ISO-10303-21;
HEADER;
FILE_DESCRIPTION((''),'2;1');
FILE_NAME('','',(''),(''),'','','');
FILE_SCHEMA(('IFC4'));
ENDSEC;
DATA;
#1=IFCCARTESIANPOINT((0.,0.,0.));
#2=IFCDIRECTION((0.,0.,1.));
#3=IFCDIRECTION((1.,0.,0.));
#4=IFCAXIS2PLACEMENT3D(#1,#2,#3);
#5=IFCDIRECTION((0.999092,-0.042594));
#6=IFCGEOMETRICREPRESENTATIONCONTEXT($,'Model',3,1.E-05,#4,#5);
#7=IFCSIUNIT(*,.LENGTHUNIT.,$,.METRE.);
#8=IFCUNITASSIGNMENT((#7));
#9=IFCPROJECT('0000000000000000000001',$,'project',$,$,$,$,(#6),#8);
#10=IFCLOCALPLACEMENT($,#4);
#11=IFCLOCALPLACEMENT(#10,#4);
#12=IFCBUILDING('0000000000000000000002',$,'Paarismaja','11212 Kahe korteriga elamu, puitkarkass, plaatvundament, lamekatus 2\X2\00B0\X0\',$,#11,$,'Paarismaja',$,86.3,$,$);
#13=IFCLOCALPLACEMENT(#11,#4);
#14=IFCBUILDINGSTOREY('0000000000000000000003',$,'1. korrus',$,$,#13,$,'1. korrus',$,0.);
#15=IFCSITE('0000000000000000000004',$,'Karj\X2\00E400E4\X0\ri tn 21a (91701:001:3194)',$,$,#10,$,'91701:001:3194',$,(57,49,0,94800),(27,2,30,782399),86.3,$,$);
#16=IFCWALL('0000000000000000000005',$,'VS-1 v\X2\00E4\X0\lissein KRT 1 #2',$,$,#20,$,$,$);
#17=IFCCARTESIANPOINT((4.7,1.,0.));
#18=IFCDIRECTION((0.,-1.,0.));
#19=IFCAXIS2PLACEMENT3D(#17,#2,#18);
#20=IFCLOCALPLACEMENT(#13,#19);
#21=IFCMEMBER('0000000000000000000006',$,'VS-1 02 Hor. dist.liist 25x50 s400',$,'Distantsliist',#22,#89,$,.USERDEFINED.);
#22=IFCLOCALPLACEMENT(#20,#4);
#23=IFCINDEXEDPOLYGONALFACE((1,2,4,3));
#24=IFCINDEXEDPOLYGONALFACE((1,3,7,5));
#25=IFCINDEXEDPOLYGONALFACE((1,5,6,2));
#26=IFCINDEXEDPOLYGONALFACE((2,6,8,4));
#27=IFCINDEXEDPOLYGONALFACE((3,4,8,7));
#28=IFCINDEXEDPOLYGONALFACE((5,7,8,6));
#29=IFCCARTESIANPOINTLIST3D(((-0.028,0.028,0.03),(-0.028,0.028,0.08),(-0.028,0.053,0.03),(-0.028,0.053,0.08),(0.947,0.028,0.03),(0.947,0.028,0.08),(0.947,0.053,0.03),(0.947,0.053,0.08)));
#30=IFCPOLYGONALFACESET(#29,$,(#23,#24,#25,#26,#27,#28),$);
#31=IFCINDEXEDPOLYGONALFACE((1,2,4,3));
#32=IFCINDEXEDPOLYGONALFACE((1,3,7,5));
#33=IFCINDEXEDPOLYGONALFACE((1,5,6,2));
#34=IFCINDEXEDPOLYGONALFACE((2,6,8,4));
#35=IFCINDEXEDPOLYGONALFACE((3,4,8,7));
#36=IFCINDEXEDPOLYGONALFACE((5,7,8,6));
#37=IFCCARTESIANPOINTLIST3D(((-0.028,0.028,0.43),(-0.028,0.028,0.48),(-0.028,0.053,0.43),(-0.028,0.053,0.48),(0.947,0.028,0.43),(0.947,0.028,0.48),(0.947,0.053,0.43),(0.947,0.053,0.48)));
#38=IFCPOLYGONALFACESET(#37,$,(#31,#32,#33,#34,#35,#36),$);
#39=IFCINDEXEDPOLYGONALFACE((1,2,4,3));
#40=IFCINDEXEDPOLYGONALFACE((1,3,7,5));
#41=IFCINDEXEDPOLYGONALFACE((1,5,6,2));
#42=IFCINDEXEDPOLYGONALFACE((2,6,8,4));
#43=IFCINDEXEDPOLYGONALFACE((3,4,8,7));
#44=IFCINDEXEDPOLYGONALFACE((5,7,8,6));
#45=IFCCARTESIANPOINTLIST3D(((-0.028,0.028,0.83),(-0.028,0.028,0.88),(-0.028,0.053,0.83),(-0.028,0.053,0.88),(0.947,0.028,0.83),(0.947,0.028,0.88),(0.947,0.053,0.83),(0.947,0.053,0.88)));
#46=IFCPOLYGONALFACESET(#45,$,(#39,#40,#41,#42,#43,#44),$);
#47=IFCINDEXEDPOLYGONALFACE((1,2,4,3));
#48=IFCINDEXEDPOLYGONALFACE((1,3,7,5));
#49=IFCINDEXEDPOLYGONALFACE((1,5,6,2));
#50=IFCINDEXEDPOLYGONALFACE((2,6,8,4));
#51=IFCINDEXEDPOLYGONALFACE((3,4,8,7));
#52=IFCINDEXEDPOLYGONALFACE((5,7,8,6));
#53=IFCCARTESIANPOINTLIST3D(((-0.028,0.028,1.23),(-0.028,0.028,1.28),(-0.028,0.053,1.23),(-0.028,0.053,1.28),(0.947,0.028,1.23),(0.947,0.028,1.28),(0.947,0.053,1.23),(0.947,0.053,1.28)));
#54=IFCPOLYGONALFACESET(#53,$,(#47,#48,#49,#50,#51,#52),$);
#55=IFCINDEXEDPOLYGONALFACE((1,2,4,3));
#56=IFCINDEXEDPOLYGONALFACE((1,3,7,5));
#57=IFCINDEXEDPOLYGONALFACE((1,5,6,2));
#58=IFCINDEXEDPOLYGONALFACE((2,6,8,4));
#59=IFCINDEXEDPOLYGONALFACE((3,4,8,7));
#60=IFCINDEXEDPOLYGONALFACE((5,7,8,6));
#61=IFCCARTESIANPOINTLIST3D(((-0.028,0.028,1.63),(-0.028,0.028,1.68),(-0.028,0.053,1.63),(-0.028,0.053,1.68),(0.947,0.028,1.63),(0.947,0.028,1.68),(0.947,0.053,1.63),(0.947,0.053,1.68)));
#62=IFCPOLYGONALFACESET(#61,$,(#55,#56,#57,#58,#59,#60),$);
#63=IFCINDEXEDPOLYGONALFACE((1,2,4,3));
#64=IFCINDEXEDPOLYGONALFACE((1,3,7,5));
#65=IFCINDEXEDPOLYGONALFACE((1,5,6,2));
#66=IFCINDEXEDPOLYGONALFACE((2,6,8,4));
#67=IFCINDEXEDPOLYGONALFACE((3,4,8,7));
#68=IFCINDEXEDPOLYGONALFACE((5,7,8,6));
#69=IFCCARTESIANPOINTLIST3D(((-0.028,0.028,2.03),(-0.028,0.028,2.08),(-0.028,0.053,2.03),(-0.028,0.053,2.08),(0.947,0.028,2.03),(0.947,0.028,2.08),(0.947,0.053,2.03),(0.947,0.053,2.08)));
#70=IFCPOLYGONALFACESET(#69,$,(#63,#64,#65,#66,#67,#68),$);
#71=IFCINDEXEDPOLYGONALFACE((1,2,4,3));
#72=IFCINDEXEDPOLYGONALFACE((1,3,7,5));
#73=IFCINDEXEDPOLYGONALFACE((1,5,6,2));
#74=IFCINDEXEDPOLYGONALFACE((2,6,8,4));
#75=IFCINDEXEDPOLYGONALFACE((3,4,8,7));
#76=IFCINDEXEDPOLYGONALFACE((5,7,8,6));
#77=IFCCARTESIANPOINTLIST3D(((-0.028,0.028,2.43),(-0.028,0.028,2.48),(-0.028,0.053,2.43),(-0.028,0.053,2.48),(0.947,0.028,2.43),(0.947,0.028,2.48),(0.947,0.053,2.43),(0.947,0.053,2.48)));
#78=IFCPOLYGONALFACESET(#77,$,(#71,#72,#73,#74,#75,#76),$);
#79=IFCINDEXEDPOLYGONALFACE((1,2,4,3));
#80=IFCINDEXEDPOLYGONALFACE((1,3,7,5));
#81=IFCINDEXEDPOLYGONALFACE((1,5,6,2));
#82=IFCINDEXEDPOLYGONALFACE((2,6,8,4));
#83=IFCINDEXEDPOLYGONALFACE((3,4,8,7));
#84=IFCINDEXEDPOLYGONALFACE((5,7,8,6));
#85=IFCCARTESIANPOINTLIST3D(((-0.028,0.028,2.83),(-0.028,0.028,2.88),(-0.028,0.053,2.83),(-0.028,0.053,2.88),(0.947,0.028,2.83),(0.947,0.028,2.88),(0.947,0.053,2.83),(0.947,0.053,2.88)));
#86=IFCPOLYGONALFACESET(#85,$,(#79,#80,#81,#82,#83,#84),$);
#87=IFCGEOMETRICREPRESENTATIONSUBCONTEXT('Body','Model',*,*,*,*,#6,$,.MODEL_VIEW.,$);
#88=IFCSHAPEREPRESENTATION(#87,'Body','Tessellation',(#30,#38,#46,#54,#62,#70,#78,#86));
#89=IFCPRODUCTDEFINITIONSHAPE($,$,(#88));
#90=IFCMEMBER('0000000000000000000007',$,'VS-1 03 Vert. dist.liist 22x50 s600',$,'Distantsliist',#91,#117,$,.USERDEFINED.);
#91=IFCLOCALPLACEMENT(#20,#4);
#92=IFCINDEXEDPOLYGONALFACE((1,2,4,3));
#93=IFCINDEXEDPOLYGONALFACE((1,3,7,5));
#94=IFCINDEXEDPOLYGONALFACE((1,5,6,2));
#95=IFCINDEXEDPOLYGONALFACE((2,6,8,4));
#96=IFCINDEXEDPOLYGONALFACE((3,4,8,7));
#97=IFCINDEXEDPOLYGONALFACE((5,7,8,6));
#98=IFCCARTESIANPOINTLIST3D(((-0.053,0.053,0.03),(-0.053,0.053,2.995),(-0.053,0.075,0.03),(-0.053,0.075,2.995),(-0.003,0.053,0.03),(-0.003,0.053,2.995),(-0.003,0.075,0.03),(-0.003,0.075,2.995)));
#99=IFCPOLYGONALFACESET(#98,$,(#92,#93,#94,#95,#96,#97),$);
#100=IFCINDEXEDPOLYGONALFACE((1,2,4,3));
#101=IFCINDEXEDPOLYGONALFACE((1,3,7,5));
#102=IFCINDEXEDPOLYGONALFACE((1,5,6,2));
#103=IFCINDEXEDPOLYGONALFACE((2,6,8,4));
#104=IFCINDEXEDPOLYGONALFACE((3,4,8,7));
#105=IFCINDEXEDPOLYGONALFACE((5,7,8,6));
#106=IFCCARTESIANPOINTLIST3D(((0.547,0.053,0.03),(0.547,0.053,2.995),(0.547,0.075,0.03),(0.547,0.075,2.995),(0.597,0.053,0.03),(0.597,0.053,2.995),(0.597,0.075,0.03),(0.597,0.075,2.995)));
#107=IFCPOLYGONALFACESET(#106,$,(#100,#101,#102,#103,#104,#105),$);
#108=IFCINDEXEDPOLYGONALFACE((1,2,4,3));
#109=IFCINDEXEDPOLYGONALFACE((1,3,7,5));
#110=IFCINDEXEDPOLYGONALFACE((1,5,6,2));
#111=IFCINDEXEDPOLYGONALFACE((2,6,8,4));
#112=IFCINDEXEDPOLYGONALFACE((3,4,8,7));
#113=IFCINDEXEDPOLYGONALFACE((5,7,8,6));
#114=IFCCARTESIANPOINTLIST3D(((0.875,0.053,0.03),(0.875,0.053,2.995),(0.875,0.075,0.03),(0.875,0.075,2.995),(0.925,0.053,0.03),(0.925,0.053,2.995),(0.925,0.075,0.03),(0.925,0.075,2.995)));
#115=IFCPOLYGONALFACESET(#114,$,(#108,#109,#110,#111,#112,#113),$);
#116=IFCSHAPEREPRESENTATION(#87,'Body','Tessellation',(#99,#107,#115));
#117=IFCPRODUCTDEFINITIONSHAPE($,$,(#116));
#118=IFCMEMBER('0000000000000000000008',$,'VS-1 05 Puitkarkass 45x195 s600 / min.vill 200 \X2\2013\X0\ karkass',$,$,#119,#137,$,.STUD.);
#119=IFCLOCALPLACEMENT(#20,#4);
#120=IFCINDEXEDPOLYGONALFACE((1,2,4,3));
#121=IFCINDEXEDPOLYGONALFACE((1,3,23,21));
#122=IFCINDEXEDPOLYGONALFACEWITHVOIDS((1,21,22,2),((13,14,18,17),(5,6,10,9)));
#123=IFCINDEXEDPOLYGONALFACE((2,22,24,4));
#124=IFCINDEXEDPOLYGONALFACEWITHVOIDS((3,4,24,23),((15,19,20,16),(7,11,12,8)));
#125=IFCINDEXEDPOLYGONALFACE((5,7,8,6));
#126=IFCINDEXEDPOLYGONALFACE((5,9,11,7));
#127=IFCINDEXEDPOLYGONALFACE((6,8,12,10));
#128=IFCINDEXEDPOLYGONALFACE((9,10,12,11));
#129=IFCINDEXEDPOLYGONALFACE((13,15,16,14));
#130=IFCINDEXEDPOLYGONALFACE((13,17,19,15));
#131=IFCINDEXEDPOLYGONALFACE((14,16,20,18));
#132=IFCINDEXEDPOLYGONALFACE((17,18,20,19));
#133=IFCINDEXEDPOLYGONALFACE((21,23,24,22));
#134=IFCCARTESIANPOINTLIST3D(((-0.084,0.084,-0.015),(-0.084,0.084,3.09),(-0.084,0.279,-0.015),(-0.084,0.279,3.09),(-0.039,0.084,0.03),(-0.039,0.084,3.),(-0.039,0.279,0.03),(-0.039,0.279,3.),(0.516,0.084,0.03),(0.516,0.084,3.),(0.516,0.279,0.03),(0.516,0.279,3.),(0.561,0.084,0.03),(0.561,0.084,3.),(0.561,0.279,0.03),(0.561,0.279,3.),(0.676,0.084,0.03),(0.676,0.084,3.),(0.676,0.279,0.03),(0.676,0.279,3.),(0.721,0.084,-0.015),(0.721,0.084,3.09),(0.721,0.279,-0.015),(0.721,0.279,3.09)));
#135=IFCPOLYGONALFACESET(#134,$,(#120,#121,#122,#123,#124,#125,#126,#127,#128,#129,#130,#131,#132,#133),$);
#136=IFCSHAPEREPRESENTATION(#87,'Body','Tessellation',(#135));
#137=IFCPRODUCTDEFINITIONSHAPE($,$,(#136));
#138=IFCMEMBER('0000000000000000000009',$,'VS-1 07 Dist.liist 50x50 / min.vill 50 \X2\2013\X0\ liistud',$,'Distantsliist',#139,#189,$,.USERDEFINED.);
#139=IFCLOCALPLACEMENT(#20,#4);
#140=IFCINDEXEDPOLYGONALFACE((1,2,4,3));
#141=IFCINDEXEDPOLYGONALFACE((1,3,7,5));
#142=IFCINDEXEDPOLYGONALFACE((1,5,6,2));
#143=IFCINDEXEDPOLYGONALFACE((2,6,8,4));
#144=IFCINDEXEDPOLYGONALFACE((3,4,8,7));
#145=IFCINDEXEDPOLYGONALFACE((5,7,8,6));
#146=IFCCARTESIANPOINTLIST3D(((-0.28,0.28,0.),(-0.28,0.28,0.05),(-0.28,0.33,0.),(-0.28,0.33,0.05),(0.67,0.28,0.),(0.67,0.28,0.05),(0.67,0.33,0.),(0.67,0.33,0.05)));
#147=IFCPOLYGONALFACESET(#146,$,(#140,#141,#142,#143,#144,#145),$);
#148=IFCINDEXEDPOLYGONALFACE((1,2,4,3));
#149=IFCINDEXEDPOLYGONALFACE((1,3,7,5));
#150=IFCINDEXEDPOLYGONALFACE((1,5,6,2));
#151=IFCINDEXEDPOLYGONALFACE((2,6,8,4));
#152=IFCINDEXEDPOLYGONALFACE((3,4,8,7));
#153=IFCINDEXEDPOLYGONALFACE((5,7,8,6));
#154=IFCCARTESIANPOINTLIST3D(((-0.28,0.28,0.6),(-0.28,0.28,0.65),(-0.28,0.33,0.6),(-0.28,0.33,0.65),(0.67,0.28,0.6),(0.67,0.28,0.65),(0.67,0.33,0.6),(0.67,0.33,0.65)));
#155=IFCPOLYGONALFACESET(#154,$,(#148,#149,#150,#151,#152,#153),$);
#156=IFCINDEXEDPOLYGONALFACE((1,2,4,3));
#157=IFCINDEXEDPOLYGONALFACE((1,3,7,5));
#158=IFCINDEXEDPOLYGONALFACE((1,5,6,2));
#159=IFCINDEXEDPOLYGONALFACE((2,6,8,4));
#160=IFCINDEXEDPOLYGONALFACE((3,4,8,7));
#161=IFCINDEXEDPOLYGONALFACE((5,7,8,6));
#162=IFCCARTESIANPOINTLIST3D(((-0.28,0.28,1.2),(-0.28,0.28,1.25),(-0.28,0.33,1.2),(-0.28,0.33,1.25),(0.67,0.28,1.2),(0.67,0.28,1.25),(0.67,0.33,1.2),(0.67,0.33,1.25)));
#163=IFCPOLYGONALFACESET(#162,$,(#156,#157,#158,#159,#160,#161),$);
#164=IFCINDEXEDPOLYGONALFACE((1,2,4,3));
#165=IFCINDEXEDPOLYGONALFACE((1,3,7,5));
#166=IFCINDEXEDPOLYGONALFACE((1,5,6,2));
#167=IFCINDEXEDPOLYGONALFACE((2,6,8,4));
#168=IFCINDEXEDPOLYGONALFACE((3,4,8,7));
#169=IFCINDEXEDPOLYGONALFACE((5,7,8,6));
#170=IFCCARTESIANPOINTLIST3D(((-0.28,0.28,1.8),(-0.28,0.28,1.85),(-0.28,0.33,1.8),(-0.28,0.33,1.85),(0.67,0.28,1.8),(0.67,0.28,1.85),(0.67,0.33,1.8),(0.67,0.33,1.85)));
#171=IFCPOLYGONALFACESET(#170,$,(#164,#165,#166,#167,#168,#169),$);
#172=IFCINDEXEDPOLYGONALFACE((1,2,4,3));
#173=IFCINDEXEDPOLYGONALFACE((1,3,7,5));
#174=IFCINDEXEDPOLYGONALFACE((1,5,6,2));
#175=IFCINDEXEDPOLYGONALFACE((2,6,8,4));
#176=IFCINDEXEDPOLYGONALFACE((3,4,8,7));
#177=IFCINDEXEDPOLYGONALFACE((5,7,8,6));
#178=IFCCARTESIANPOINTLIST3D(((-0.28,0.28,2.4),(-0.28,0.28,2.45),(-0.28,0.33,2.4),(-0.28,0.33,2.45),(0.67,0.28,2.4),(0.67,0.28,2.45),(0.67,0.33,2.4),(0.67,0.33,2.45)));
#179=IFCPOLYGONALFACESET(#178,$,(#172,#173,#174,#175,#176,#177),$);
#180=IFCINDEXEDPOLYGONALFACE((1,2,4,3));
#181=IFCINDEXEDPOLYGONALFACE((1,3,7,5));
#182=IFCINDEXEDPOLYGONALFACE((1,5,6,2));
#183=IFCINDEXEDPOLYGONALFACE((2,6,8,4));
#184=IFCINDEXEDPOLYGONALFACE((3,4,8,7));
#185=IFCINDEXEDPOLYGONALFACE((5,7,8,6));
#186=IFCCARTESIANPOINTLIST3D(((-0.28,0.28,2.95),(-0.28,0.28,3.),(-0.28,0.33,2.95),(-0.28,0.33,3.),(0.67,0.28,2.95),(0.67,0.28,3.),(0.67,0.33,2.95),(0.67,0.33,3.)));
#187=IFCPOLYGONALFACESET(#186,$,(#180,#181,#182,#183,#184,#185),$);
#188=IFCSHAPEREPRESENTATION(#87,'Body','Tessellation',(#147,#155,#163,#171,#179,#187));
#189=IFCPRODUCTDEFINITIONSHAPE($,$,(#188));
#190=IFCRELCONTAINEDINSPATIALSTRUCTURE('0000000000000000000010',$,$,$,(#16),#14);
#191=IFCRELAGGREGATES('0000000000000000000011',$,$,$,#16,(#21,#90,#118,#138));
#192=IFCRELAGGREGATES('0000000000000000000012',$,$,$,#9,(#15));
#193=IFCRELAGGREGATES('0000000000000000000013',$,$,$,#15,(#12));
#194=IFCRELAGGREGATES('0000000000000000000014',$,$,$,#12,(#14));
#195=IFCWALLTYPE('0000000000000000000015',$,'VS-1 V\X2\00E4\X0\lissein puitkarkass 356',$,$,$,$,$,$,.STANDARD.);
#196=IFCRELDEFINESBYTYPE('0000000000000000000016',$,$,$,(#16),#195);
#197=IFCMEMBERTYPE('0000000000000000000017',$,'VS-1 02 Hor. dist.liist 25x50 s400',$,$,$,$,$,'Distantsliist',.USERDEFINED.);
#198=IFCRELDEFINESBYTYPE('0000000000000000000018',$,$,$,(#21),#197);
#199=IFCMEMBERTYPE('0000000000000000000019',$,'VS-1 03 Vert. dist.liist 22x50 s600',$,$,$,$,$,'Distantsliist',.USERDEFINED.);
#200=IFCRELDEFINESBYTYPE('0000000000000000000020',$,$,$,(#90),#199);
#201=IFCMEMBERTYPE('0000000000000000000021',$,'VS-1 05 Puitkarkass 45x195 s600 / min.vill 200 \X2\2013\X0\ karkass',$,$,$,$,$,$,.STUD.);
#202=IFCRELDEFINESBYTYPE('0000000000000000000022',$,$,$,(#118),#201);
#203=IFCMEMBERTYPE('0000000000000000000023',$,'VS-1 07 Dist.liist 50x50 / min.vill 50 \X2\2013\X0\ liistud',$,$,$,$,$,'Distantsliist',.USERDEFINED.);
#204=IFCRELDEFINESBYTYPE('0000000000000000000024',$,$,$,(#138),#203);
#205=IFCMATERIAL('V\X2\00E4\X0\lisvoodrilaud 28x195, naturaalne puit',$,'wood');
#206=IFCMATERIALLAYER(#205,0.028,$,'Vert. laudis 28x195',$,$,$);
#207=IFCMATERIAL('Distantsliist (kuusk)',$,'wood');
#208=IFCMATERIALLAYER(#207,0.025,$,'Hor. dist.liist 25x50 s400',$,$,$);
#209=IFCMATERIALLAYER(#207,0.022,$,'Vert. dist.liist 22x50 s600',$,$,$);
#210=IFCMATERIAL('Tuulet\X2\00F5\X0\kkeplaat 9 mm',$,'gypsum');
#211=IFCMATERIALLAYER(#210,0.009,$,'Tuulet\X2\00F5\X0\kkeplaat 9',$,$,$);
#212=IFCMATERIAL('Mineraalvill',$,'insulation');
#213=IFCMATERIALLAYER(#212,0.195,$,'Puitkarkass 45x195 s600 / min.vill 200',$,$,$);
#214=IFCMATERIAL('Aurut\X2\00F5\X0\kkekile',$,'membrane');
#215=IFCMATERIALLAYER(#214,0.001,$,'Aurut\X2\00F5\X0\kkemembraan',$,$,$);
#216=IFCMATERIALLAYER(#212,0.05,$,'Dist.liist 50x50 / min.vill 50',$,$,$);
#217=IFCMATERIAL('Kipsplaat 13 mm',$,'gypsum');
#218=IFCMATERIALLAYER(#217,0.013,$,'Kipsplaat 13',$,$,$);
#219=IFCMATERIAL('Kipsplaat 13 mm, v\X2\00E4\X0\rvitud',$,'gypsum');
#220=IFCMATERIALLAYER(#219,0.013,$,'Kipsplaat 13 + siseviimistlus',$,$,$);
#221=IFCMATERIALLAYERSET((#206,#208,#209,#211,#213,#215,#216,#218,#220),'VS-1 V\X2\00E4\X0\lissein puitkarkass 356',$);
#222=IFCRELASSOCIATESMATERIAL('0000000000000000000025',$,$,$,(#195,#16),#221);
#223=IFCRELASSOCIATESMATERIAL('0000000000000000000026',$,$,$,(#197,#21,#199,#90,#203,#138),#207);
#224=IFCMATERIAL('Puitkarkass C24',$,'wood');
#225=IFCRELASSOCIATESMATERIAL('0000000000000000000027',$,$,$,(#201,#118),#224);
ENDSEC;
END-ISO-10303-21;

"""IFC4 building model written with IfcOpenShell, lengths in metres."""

from ifc_helpers import new_model, si_unit, direction, frame, origin_with_axes, place, context, subcontext, project, spatial, indexed_curve, outline, extrude, material, layer, layer_set, layer_usage, type_object, element, aggregate, save


model = new_model("IFC4")

# Units and contexts
model_context = context("Model", 3, precision=1e-05, world=origin_with_axes(), true_north=direction((0.999092, -0.042594)))
body_context = subcontext(model_context, "Body", "Model", "MODEL_VIEW")
ifc_project = project(units=[si_unit("LENGTHUNIT", "METRE")], contexts=[model_context])

# Site, building, storey
site_placement = place(None, origin_with_axes())
site = spatial("IfcSite", under=ifc_project, at=site_placement, Name="Karjääri tn 21a (91701:001:3194)", LongName="91701:001:3194", RefLatitude=(57, 49, 0, 94800), RefLongitude=(27, 2, 30, 782399), RefElevation=86.3)
building_placement = place(site_placement, origin_with_axes())
building = spatial("IfcBuilding", under=site, at=building_placement, Name="Paarismaja", Description="11212 Kahe korteriga elamu, puitkarkass, plaatvundament, lamekatus 2°", LongName="Paarismaja", ElevationOfRefHeight=86.3)
storey_placement = place(building_placement, origin_with_axes())
storey = spatial("IfcBuildingStorey", under=building, at=storey_placement, Name="1. korrus", LongName="1. korrus", Elevation=0.0)

# Wall, members
ifc_material_1 = material(Name="Välisvoodrilaud 28x195, naturaalne puit", Category="wood")
ifc_layer_1 = layer(ifc_material_1, 0.028, Name="Vert. laudis 28x195")
ifc_material_2 = material(Name="Distantsliist (kuusk)", Category="wood")
ifc_layer_2 = layer(ifc_material_2, 0.025, Name="Hor. dist.liist 25x50 s400")
ifc_layer_3 = layer(ifc_material_2, 0.022, Name="Vert. dist.liist 22x50 s600")
ifc_material_3 = material(Name="Tuuletõkkeplaat 9 mm", Category="gypsum")
ifc_layer_4 = layer(ifc_material_3, 0.009, Name="Tuuletõkkeplaat 9")
ifc_material_4 = material(Name="Mineraalvill", Category="insulation")
ifc_layer_5 = layer(ifc_material_4, 0.195, Name="Puitkarkass 45x195 s600 / min.vill 200")
ifc_material_5 = material(Name="Aurutõkkekile", Category="membrane")
ifc_layer_6 = layer(ifc_material_5, 0.001, Name="Aurutõkkemembraan")
ifc_layer_7 = layer(ifc_material_4, 0.05, Name="Dist.liist 50x50 / min.vill 50")
ifc_material_6 = material(Name="Kipsplaat 13 mm", Category="gypsum")
ifc_layer_8 = layer(ifc_material_6, 0.013, Name="Kipsplaat 13")
ifc_material_7 = material(Name="Kipsplaat 13 mm, värvitud", Category="gypsum")
ifc_layer_9 = layer(ifc_material_7, 0.013, Name="Kipsplaat 13 + siseviimistlus")
ifc_layer_set_1 = layer_set([ifc_layer_1, ifc_layer_2, ifc_layer_3, ifc_layer_4, ifc_layer_5, ifc_layer_6, ifc_layer_7, ifc_layer_8, ifc_layer_9], Name="VS-1 Välissein puitkarkass 356")
ifc_layer_usage_1 = layer_usage(ifc_layer_set_1, "AXIS2", "POSITIVE", 0.0)
wall_type = type_object("IfcWallType", Name="VS-1 Välissein puitkarkass 356", PredefinedType="STANDARD", material=ifc_layer_set_1)
wall_placement = place(storey_placement, frame((4.7, 1.0, 0.0), z_axis=(0.0, 0.0, 1.0), x_axis=(0.0, -1.0, 0.0)))
wall = element("IfcWall", 1, at=wall_placement, inside=storey, type_object=wall_type, material=ifc_layer_usage_1, Name="VS-1 välissein KRT 1 #2")
member_type_1 = type_object("IfcMemberType", Name="VS-1 02 Hor. dist.liist 25x50 s400", ElementType="Distantsliist", PredefinedType="USERDEFINED", material=ifc_material_2)
member_1_placement = place(wall_placement, origin_with_axes())
member_1 = element("IfcMember", 2, at=member_1_placement, type_object=member_type_1, material=ifc_material_2, Name="VS-1 02 Hor. dist.liist 25x50 s400", ObjectType="Distantsliist", PredefinedType="USERDEFINED", context=body_context, shape_type="SweptSolid", body=[
    extrude(outline(indexed_curve([(0.947, 0.03), (-0.028, 0.03), (-0.028, 0.08), (0.947, 0.08), (0.947, 0.03)], self_intersect=False)), frame((0.0, 0.053, 0.0), z_axis=(0.0, -1.0, 0.0), x_axis=(1.0, 0.0, 0.0)), (0.0, 0.0, 1.0), 0.025),
    extrude(outline(indexed_curve([(0.947, 0.43), (-0.028, 0.43), (-0.028, 0.48), (0.947, 0.48), (0.947, 0.43)], self_intersect=False)), frame((0.0, 0.053, 0.0), z_axis=(0.0, -1.0, 0.0), x_axis=(1.0, 0.0, 0.0)), (0.0, 0.0, 1.0), 0.025),
    extrude(outline(indexed_curve([(0.947, 0.83), (-0.028, 0.83), (-0.028, 0.88), (0.947, 0.88), (0.947, 0.83)], self_intersect=False)), frame((0.0, 0.053, 0.0), z_axis=(0.0, -1.0, 0.0), x_axis=(1.0, 0.0, 0.0)), (0.0, 0.0, 1.0), 0.025),
    extrude(outline(indexed_curve([(0.947, 1.23), (-0.028, 1.23), (-0.028, 1.28), (0.947, 1.28), (0.947, 1.23)], self_intersect=False)), frame((0.0, 0.053, 0.0), z_axis=(0.0, -1.0, 0.0), x_axis=(1.0, 0.0, 0.0)), (0.0, 0.0, 1.0), 0.025),
    extrude(outline(indexed_curve([(0.947, 1.63), (-0.028, 1.63), (-0.028, 1.68), (0.947, 1.68), (0.947, 1.63)], self_intersect=False)), frame((0.0, 0.053, 0.0), z_axis=(0.0, -1.0, 0.0), x_axis=(1.0, 0.0, 0.0)), (0.0, 0.0, 1.0), 0.025),
    extrude(outline(indexed_curve([(0.947, 2.03), (-0.028, 2.03), (-0.028, 2.08), (0.947, 2.08), (0.947, 2.03)], self_intersect=False)), frame((0.0, 0.053, 0.0), z_axis=(0.0, -1.0, 0.0), x_axis=(1.0, 0.0, 0.0)), (0.0, 0.0, 1.0), 0.025),
    extrude(outline(indexed_curve([(0.947, 2.43), (-0.028, 2.43), (-0.028, 2.48), (0.947, 2.48), (0.947, 2.43)], self_intersect=False)), frame((0.0, 0.053, 0.0), z_axis=(0.0, -1.0, 0.0), x_axis=(1.0, 0.0, 0.0)), (0.0, 0.0, 1.0), 0.025),
    extrude(outline(indexed_curve([(0.947, 2.83), (-0.028, 2.83), (-0.028, 2.88), (0.947, 2.88), (0.947, 2.83)], self_intersect=False)), frame((0.0, 0.053, 0.0), z_axis=(0.0, -1.0, 0.0), x_axis=(1.0, 0.0, 0.0)), (0.0, 0.0, 1.0), 0.025),
])
member_type_2 = type_object("IfcMemberType", Name="VS-1 03 Vert. dist.liist 22x50 s600", ElementType="Distantsliist", PredefinedType="USERDEFINED", material=ifc_material_2)
member_2_placement = place(wall_placement, origin_with_axes())
member_2 = element("IfcMember", 3, at=member_2_placement, type_object=member_type_2, material=ifc_material_2, Name="VS-1 03 Vert. dist.liist 22x50 s600", ObjectType="Distantsliist", PredefinedType="USERDEFINED", context=body_context, shape_type="SweptSolid", body=[
    extrude(outline(indexed_curve([(-0.003, 0.03), (-0.053, 0.03), (-0.053, 2.995), (-0.003, 2.995), (-0.003, 0.03)], self_intersect=False)), frame((0.0, 0.075, 0.0), z_axis=(0.0, -1.0, 0.0), x_axis=(1.0, 0.0, 0.0)), (0.0, 0.0, 1.0), 0.022),
    extrude(outline(indexed_curve([(0.597, 0.03), (0.547, 0.03), (0.547, 2.995), (0.597, 2.995), (0.597, 0.03)], self_intersect=False)), frame((0.0, 0.075, 0.0), z_axis=(0.0, -1.0, 0.0), x_axis=(1.0, 0.0, 0.0)), (0.0, 0.0, 1.0), 0.022),
    extrude(outline(indexed_curve([(0.925, 0.03), (0.875, 0.03), (0.875, 2.995), (0.925, 2.995), (0.925, 0.03)], self_intersect=False)), frame((0.0, 0.075, 0.0), z_axis=(0.0, -1.0, 0.0), x_axis=(1.0, 0.0, 0.0)), (0.0, 0.0, 1.0), 0.022),
])
ifc_material_8 = material(Name="Puitkarkass C24", Category="wood")
member_type_3 = type_object("IfcMemberType", Name="VS-1 05 Puitkarkass 45x195 s600 / min.vill 200 – karkass", PredefinedType="STUD", material=ifc_material_8)
member_3_placement = place(wall_placement, origin_with_axes())
member_3 = element("IfcMember", 4, at=member_3_placement, type_object=member_type_3, material=ifc_material_8, Name="VS-1 05 Puitkarkass 45x195 s600 / min.vill 200 – karkass", PredefinedType="STUD", context=body_context, shape_type="SweptSolid", body=[
    extrude(outline(indexed_curve([(0.721, -0.015), (-0.084, -0.015), (-0.084, 3.09), (0.721, 3.09), (0.721, -0.015)], self_intersect=False), holes=[indexed_curve([(0.516, 0.03), (0.516, 3.0), (-0.039, 3.0), (-0.039, 0.03), (0.516, 0.03)], self_intersect=False), indexed_curve([(0.676, 3.0), (0.561, 3.0), (0.561, 0.03), (0.676, 0.03), (0.676, 3.0)], self_intersect=False)]), frame((0.0, 0.279, 0.0), z_axis=(0.0, -1.0, 0.0), x_axis=(1.0, 0.0, 0.0)), (0.0, 0.0, 1.0), 0.195),
])
member_type_4 = type_object("IfcMemberType", Name="VS-1 07 Dist.liist 50x50 / min.vill 50 – liistud", ElementType="Distantsliist", PredefinedType="USERDEFINED", material=ifc_material_2)
member_4_placement = place(wall_placement, origin_with_axes())
member_4 = element("IfcMember", 5, at=member_4_placement, type_object=member_type_4, material=ifc_material_2, Name="VS-1 07 Dist.liist 50x50 / min.vill 50 – liistud", ObjectType="Distantsliist", PredefinedType="USERDEFINED", context=body_context, shape_type="SweptSolid", body=[
    extrude(outline(indexed_curve([(0.67, 0.05), (0.67, 0.0), (-0.28, 0.0), (-0.28, 0.05), (0.67, 0.05)], self_intersect=False)), frame((0.0, 0.33, 0.0), z_axis=(0.0, -1.0, 0.0), x_axis=(1.0, 0.0, 0.0)), (0.0, 0.0, 1.0), 0.05),
    extrude(outline(indexed_curve([(0.67, 0.6), (-0.28, 0.6), (-0.28, 0.65), (0.67, 0.65), (0.67, 0.6)], self_intersect=False)), frame((0.0, 0.33, 0.0), z_axis=(0.0, -1.0, 0.0), x_axis=(1.0, 0.0, 0.0)), (0.0, 0.0, 1.0), 0.05),
    extrude(outline(indexed_curve([(0.67, 1.2), (-0.28, 1.2), (-0.28, 1.25), (0.67, 1.25), (0.67, 1.2)], self_intersect=False)), frame((0.0, 0.33, 0.0), z_axis=(0.0, -1.0, 0.0), x_axis=(1.0, 0.0, 0.0)), (0.0, 0.0, 1.0), 0.05),
    extrude(outline(indexed_curve([(0.67, 1.85), (0.67, 1.8), (-0.28, 1.8), (-0.28, 1.85), (0.67, 1.85)], self_intersect=False)), frame((0.0, 0.33, 0.0), z_axis=(0.0, -1.0, 0.0), x_axis=(1.0, 0.0, 0.0)), (0.0, 0.0, 1.0), 0.05),
    extrude(outline(indexed_curve([(0.67, 2.4), (-0.28, 2.4), (-0.28, 2.45), (0.67, 2.45), (0.67, 2.4)], self_intersect=False)), frame((0.0, 0.33, 0.0), z_axis=(0.0, -1.0, 0.0), x_axis=(1.0, 0.0, 0.0)), (0.0, 0.0, 1.0), 0.05),
    extrude(outline(indexed_curve([(0.67, 2.95), (-0.28, 2.95), (-0.28, 3.0), (0.67, 3.0), (0.67, 2.95)], self_intersect=False)), frame((0.0, 0.33, 0.0), z_axis=(0.0, -1.0, 0.0), x_axis=(1.0, 0.0, 0.0)), (0.0, 0.0, 1.0), 0.05),
])

aggregate(wall, [member_1, member_2, member_3, member_4])

save(model, "model.ifc")
